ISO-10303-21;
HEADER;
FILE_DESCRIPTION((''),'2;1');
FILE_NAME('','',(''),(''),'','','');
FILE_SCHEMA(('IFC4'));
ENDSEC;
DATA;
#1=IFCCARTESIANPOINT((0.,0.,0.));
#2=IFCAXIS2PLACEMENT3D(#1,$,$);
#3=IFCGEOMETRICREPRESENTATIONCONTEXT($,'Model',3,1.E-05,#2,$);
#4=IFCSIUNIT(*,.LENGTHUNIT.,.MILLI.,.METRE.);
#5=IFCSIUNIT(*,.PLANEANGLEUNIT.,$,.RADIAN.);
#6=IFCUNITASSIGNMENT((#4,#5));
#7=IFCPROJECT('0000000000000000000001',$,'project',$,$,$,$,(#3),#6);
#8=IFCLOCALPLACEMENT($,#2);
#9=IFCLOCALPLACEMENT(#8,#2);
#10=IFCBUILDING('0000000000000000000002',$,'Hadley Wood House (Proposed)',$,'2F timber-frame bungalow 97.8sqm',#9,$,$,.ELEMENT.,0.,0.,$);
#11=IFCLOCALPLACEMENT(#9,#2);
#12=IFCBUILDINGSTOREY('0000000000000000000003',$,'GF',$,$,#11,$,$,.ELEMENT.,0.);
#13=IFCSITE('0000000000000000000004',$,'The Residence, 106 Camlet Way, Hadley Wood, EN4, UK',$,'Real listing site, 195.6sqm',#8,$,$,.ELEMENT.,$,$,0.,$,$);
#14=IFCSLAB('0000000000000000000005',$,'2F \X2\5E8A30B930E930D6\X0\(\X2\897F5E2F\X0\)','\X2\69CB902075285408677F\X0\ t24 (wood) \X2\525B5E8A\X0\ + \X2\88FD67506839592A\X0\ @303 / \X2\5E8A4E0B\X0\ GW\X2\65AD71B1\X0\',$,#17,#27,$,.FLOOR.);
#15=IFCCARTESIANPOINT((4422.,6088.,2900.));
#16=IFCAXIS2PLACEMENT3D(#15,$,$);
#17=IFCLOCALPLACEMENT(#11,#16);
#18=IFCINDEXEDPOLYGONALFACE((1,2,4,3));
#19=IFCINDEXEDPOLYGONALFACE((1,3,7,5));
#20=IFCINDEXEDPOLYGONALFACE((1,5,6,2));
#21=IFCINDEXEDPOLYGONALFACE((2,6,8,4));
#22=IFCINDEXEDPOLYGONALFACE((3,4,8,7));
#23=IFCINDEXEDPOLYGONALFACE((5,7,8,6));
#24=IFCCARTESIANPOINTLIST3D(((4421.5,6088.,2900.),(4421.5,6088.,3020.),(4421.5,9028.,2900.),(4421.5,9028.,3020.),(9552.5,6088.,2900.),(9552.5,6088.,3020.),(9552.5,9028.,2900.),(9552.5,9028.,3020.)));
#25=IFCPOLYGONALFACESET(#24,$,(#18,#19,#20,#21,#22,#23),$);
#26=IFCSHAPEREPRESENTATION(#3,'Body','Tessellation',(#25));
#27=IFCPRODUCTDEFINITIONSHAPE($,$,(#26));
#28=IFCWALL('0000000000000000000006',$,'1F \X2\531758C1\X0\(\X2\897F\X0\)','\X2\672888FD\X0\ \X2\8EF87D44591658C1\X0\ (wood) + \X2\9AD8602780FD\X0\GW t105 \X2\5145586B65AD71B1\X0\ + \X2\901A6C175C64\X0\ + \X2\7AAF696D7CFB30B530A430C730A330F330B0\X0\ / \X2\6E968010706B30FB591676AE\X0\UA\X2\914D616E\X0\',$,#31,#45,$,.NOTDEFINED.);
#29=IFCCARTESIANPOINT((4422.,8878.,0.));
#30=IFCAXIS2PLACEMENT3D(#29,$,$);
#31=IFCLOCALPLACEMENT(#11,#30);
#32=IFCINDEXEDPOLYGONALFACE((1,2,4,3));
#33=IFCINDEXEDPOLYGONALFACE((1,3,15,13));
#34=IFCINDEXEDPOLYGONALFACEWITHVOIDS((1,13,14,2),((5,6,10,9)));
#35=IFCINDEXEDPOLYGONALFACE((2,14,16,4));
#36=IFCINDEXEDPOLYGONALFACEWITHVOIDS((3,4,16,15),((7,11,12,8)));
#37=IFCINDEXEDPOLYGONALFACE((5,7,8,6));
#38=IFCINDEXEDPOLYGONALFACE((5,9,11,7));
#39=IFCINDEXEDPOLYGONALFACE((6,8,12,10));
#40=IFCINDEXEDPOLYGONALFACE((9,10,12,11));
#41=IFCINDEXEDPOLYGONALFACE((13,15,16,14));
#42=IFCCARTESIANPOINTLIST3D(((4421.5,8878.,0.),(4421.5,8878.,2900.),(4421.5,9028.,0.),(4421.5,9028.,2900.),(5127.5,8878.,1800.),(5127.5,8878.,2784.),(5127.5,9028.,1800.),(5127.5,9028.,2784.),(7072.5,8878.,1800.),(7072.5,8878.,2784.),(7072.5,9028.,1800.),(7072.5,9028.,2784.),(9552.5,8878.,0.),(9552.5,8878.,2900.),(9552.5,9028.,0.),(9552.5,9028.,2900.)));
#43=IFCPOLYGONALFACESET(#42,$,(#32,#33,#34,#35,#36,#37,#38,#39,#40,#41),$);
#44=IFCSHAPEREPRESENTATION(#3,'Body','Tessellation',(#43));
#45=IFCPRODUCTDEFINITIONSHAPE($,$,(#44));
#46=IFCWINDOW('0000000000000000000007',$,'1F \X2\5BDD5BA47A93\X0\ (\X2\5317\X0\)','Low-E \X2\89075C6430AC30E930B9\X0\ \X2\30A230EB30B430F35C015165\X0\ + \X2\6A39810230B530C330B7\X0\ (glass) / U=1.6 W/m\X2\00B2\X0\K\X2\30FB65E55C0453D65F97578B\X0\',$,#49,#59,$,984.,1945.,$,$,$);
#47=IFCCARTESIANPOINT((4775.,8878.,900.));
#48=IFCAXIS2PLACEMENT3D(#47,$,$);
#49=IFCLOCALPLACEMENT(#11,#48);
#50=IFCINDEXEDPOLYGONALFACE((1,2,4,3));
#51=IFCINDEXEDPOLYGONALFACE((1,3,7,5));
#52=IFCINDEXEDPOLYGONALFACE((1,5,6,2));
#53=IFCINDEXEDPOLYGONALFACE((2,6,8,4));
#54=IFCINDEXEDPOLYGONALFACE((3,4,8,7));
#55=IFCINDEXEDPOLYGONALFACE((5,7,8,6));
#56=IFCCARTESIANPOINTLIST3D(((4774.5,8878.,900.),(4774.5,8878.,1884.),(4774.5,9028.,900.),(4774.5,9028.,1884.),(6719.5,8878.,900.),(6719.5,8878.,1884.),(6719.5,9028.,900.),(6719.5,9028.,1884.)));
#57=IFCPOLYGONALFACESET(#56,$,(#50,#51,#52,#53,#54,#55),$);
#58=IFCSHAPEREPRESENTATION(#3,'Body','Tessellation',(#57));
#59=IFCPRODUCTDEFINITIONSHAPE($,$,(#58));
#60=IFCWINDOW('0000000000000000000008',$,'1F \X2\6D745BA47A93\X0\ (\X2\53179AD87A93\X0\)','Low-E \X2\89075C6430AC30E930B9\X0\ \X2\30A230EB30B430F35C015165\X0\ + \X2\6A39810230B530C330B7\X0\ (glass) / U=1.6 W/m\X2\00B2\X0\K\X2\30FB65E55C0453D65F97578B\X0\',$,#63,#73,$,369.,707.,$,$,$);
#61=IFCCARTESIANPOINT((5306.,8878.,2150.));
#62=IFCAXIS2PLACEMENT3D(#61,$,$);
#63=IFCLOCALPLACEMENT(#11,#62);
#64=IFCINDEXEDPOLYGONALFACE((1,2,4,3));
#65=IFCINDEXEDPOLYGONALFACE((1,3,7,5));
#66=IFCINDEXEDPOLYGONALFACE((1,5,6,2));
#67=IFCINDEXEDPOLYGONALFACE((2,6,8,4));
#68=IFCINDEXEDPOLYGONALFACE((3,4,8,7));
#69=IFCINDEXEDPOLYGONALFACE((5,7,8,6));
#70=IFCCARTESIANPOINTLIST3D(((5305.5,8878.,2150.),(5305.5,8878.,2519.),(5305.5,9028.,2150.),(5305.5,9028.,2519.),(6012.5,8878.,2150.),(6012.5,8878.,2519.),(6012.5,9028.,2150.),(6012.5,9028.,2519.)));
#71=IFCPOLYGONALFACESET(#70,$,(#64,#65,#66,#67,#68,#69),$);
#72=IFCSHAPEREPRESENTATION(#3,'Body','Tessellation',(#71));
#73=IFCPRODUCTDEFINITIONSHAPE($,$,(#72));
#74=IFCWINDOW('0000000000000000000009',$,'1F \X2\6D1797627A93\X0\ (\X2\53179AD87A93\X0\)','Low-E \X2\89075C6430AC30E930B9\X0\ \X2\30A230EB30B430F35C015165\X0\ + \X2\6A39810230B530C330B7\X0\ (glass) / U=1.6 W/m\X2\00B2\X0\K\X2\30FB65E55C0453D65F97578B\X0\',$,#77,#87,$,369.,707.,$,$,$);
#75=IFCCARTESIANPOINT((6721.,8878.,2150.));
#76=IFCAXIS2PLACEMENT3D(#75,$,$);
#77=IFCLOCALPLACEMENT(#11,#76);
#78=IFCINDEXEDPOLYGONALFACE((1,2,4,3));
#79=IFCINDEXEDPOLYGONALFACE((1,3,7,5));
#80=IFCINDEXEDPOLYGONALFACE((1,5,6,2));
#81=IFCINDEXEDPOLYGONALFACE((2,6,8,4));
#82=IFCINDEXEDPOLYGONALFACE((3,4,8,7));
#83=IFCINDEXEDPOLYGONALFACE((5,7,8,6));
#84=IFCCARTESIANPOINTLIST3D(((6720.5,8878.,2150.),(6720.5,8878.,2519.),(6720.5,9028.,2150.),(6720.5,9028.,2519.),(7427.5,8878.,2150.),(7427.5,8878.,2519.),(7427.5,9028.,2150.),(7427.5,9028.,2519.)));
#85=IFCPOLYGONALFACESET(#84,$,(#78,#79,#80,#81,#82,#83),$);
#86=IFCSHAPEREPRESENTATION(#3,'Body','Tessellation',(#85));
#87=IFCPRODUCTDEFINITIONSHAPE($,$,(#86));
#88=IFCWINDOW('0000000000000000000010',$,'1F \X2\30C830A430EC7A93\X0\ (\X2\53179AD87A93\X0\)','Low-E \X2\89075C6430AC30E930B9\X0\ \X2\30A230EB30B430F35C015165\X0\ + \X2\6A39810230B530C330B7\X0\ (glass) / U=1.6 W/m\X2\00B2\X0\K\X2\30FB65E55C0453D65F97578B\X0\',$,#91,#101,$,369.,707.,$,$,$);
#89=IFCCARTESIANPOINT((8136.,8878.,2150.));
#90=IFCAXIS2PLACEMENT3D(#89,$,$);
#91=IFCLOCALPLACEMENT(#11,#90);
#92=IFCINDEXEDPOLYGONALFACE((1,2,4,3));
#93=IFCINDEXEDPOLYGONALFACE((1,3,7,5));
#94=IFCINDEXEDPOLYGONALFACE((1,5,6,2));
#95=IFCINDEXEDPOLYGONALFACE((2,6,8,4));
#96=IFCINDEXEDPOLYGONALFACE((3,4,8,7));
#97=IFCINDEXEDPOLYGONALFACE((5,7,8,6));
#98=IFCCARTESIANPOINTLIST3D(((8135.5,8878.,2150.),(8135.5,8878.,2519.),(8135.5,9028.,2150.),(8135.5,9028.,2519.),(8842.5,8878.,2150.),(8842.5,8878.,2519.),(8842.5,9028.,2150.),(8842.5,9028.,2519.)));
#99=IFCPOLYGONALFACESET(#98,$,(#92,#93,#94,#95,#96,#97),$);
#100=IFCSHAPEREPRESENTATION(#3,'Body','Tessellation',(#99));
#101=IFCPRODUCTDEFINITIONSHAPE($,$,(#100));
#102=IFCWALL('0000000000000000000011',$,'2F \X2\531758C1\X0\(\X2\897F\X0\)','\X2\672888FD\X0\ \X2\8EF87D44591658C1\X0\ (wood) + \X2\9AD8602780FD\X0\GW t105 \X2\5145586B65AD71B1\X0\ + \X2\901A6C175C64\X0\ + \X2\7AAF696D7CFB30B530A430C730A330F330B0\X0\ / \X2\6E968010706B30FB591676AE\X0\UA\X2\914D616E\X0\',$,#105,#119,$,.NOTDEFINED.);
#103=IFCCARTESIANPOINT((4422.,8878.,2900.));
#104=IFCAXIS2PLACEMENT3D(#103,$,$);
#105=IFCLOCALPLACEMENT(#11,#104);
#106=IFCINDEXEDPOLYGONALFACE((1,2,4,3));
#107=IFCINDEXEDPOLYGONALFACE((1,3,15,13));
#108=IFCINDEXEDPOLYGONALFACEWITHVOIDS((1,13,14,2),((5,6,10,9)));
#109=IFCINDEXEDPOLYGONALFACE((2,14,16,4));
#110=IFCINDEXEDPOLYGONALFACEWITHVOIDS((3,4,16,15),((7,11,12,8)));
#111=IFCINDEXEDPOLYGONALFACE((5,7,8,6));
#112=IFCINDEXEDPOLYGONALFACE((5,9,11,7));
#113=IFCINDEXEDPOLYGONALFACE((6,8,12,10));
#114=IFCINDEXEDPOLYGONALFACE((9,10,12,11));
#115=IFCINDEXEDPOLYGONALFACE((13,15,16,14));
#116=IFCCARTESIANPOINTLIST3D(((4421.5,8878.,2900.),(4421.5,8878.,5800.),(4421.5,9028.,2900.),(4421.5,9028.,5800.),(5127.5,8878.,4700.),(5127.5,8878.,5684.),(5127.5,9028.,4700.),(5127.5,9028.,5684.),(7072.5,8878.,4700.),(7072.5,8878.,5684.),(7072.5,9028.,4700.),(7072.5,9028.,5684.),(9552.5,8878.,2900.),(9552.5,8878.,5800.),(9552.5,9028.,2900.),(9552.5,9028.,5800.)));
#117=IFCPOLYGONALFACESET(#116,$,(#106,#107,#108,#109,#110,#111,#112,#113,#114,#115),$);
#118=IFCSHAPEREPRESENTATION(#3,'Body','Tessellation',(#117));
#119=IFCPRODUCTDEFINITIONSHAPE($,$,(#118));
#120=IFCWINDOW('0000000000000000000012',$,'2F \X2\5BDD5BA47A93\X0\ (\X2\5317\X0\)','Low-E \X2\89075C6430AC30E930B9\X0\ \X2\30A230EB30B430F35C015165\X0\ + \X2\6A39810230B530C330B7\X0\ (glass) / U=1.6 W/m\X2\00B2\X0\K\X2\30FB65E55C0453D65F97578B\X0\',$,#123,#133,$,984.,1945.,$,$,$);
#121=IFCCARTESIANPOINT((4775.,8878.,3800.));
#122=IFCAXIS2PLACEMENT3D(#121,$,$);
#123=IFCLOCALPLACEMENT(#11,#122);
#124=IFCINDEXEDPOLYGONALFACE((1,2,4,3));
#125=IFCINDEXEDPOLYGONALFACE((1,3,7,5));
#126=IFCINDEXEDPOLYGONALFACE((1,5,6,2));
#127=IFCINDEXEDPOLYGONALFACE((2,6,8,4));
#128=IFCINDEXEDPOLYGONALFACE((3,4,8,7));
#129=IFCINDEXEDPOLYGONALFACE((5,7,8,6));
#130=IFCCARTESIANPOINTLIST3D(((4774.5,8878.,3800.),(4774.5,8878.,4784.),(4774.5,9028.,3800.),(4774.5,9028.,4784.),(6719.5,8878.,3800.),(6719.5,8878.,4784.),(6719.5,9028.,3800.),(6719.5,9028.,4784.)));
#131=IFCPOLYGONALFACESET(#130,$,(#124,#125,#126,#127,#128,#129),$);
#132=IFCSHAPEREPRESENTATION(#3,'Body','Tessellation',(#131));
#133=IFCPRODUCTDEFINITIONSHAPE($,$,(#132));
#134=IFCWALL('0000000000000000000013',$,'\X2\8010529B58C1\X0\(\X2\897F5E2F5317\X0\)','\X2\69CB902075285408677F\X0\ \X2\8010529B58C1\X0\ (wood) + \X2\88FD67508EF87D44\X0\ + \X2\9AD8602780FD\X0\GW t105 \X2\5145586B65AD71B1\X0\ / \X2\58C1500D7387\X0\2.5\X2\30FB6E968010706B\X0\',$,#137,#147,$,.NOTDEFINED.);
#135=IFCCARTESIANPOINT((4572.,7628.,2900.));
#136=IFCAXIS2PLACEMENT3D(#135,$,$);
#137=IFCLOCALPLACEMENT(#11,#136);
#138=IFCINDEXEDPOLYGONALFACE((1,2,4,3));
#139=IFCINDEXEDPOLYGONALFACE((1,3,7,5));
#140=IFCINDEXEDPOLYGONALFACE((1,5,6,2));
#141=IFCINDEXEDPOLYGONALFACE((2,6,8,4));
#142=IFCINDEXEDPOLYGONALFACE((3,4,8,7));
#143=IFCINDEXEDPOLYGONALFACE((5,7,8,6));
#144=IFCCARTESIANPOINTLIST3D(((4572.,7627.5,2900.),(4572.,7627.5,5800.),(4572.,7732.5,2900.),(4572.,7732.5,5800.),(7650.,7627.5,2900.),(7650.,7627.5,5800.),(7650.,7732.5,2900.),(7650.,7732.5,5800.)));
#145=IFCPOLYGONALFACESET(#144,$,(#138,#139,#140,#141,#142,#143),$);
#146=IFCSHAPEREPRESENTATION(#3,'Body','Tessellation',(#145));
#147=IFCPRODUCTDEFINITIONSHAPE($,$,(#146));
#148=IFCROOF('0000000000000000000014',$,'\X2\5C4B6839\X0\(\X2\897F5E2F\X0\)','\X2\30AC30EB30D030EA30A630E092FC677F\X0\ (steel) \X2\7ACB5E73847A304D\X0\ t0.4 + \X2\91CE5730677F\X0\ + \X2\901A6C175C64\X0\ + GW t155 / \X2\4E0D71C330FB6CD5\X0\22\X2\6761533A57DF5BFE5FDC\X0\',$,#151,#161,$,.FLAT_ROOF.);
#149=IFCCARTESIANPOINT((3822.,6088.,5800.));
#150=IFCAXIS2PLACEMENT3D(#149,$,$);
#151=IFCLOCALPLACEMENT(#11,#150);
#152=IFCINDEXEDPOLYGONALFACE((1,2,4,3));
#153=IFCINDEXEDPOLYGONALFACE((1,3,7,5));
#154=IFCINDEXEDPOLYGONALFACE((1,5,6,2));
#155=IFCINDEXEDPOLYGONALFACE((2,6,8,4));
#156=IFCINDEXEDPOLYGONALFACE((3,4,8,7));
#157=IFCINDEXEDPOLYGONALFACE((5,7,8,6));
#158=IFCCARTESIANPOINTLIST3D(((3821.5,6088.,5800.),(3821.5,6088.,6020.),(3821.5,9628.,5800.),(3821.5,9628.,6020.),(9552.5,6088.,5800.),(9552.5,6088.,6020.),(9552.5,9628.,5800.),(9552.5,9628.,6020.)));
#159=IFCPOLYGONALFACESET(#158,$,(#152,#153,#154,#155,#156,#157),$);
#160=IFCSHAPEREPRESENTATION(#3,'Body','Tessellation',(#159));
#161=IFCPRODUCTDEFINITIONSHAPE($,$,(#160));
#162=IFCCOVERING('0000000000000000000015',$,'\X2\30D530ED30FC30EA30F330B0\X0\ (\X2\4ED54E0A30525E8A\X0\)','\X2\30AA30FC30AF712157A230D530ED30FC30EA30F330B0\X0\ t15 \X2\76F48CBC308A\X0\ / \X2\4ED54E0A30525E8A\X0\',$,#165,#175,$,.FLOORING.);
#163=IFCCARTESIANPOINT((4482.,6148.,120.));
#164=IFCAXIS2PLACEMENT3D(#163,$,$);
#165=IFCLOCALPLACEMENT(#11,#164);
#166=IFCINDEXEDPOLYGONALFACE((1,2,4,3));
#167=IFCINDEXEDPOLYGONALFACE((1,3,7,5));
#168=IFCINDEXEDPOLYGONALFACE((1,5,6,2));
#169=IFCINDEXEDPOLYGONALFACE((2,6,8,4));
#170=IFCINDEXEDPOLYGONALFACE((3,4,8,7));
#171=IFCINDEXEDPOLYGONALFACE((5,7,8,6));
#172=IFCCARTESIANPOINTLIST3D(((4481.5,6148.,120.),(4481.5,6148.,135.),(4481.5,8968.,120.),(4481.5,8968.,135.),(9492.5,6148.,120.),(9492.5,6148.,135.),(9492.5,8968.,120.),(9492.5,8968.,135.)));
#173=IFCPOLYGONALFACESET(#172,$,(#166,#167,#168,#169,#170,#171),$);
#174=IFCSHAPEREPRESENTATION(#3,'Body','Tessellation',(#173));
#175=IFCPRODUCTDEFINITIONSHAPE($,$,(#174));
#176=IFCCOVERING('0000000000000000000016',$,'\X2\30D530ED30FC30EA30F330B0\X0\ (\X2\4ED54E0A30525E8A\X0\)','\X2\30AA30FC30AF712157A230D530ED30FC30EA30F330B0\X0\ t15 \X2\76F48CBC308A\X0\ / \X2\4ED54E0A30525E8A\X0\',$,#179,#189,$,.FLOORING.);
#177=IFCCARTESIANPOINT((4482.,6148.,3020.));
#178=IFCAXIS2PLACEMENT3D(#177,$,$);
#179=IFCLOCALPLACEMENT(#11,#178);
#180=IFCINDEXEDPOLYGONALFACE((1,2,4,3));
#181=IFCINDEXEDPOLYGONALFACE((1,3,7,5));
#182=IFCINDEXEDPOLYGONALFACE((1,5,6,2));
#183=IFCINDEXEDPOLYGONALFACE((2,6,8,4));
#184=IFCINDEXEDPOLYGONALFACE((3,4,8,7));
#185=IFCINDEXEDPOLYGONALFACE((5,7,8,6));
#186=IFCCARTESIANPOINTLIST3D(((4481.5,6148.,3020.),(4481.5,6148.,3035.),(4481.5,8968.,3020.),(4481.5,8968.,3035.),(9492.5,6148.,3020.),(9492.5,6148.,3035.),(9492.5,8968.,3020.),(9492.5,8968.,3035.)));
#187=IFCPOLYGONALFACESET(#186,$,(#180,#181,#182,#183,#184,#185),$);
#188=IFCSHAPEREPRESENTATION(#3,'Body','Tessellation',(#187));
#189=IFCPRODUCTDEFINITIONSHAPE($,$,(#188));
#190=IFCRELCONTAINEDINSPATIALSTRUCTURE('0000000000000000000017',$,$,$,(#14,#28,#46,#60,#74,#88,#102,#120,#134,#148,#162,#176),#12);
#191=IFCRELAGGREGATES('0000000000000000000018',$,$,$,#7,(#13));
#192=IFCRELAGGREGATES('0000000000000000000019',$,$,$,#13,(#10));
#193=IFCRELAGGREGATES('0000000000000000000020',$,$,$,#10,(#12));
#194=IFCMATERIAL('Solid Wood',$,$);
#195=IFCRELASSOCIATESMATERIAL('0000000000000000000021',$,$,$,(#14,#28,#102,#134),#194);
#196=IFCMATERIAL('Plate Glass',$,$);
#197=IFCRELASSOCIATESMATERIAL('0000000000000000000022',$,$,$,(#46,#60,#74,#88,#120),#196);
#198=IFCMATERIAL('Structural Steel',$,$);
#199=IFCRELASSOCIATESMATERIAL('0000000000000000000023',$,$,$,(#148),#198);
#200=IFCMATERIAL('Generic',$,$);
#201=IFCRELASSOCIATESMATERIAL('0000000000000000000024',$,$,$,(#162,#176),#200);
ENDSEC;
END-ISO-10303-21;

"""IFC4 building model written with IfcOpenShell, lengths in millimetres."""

from ifc_helpers import new_model, si_unit, frame, frame_2d, origin, place, context, project, spatial, rectangle, extrude, material, element, fill, save


model = new_model("IFC4")

# Units and contexts
model_context = context("Model", 3, precision=1e-05, world=origin())
ifc_project = project(units=[si_unit("LENGTHUNIT", "METRE", prefix="MILLI"), si_unit("PLANEANGLEUNIT", "RADIAN")], contexts=[model_context])

# Site, building, storey
site_placement = place(None, origin())
site = spatial("IfcSite", under=ifc_project, at=site_placement, Name="The Residence, 106 Camlet Way, Hadley Wood, EN4, UK", ObjectType="Real listing site, 195.6sqm", CompositionType="ELEMENT", RefElevation=0.0)
building_placement = place(site_placement, origin())
building = spatial("IfcBuilding", under=site, at=building_placement, Name="Hadley Wood House (Proposed)", ObjectType="2F timber-frame bungalow 97.8sqm", CompositionType="ELEMENT", ElevationOfRefHeight=0.0, ElevationOfTerrain=0.0)
storey_placement = place(building_placement, origin())
storey = spatial("IfcBuildingStorey", under=building, at=storey_placement, Name="GF", CompositionType="ELEMENT", Elevation=0.0)

# Slab
ifc_material_1 = material(Name="Solid Wood")
slab_1_placement = place(storey_placement, frame((4422.0, 6088.0, 2900.0)))
element("IfcSlab", 1, at=slab_1_placement, inside=storey, material=ifc_material_1, Name="2F 床スラブ(西帯)", Description="構造用合板 t24 (wood) 剛床 + 製材根太 @303 / 床下 GW断熱", PredefinedType="FLOOR", context=model_context, shape_type="SweptSolid", body=[
    extrude(rectangle(XDim=5131.0, YDim=2940.0, at=frame_2d((2565.0, 1470.0))), frame((4422.0, 6088.0, 2900.0)), (0.0, 0.0, 1.0), 120.0),
])

# Wall, openings, windows
wall_1_placement = place(storey_placement, frame((4422.0, 8878.0, 0.0)))
wall_1 = element("IfcWall", 2, at=wall_1_placement, inside=storey, material=ifc_material_1, Name="1F 北壁(西)", Description="木製 軸組外壁 (wood) + 高性能GW t105 充填断熱 + 通気層 + 窯業系サイディング / 準耐火・外皮UA配慮", PredefinedType="NOTDEFINED", context=model_context, shape_type="SweptSolid", body=[
    extrude(rectangle(XDim=5131.0, YDim=150.0, at=frame_2d((2565.0, 75.0))), frame((4422.0, 8878.0, 0.0)), (0.0, 0.0, 1.0), 2900.0),
])
opening_1_placement = place(storey_placement, frame((4775.0, 8878.0, 900.0)))
opening_1 = element("IfcOpeningElement", 3, at=opening_1_placement, cuts=wall_1, PredefinedType="NOTDEFINED", context=model_context, shape_type="SweptSolid", body=[
    extrude(rectangle(XDim=1945.0, YDim=150.0, at=frame_2d((972.0, 75.0))), frame((4775.0, 8878.0, 900.0)), (0.0, 0.0, 1.0), 984.0),
])
opening_2_placement = place(storey_placement, frame((5306.0, 8878.0, 2150.0)))
opening_2 = element("IfcOpeningElement", 4, at=opening_2_placement, cuts=wall_1, PredefinedType="NOTDEFINED", context=model_context, shape_type="SweptSolid", body=[
    extrude(rectangle(XDim=707.0, YDim=150.0, at=frame_2d((353.0, 75.0))), frame((5306.0, 8878.0, 2150.0)), (0.0, 0.0, 1.0), 369.0),
])
opening_3_placement = place(storey_placement, frame((6721.0, 8878.0, 2150.0)))
opening_3 = element("IfcOpeningElement", 5, at=opening_3_placement, cuts=wall_1, PredefinedType="NOTDEFINED", context=model_context, shape_type="SweptSolid", body=[
    extrude(rectangle(XDim=707.0, YDim=150.0, at=frame_2d((353.0, 75.0))), frame((6721.0, 8878.0, 2150.0)), (0.0, 0.0, 1.0), 369.0),
])
opening_4_placement = place(storey_placement, frame((8136.0, 8878.0, 2150.0)))
opening_4 = element("IfcOpeningElement", 6, at=opening_4_placement, cuts=wall_1, PredefinedType="NOTDEFINED", context=model_context, shape_type="SweptSolid", body=[
    extrude(rectangle(XDim=707.0, YDim=150.0, at=frame_2d((353.0, 75.0))), frame((8136.0, 8878.0, 2150.0)), (0.0, 0.0, 1.0), 369.0),
])
ifc_material_2 = material(Name="Plate Glass")
window_1_placement = place(storey_placement, frame((4775.0, 8878.0, 900.0)))
window_1 = element("IfcWindow", 7, at=window_1_placement, inside=storey, material=ifc_material_2, Name="1F 寝室窓 (北)", Description="Low-E 複層ガラス アルゴン封入 + 樹脂サッシ (glass) / U=1.6 W/m²K・日射取得型", OverallHeight=984.0, OverallWidth=1945.0, context=model_context, shape_type="SweptSolid", body=[
    extrude(rectangle(XDim=1945.0, YDim=150.0, at=frame_2d((972.0, 75.0))), frame((4775.0, 8878.0, 900.0)), (0.0, 0.0, 1.0), 984.0),
])
fill(opening_1, window_1)
window_2_placement = place(storey_placement, frame((5306.0, 8878.0, 2150.0)))
window_2 = element("IfcWindow", 8, at=window_2_placement, inside=storey, material=ifc_material_2, Name="1F 浴室窓 (北高窓)", Description="Low-E 複層ガラス アルゴン封入 + 樹脂サッシ (glass) / U=1.6 W/m²K・日射取得型", OverallHeight=369.0, OverallWidth=707.0, context=model_context, shape_type="SweptSolid", body=[
    extrude(rectangle(XDim=707.0, YDim=150.0, at=frame_2d((353.0, 75.0))), frame((5306.0, 8878.0, 2150.0)), (0.0, 0.0, 1.0), 369.0),
])
fill(opening_2, window_2)
window_3_placement = place(storey_placement, frame((6721.0, 8878.0, 2150.0)))
window_3 = element("IfcWindow", 9, at=window_3_placement, inside=storey, material=ifc_material_2, Name="1F 洗面窓 (北高窓)", Description="Low-E 複層ガラス アルゴン封入 + 樹脂サッシ (glass) / U=1.6 W/m²K・日射取得型", OverallHeight=369.0, OverallWidth=707.0, context=model_context, shape_type="SweptSolid", body=[
    extrude(rectangle(XDim=707.0, YDim=150.0, at=frame_2d((353.0, 75.0))), frame((6721.0, 8878.0, 2150.0)), (0.0, 0.0, 1.0), 369.0),
])
fill(opening_3, window_3)
window_4_placement = place(storey_placement, frame((8136.0, 8878.0, 2150.0)))
window_4 = element("IfcWindow", 10, at=window_4_placement, inside=storey, material=ifc_material_2, Name="1F トイレ窓 (北高窓)", Description="Low-E 複層ガラス アルゴン封入 + 樹脂サッシ (glass) / U=1.6 W/m²K・日射取得型", OverallHeight=369.0, OverallWidth=707.0, context=model_context, shape_type="SweptSolid", body=[
    extrude(rectangle(XDim=707.0, YDim=150.0, at=frame_2d((353.0, 75.0))), frame((8136.0, 8878.0, 2150.0)), (0.0, 0.0, 1.0), 369.0),
])
fill(opening_4, window_4)

# Wall, opening, window
wall_2_placement = place(storey_placement, frame((4422.0, 8878.0, 2900.0)))
wall_2 = element("IfcWall", 11, at=wall_2_placement, inside=storey, material=ifc_material_1, Name="2F 北壁(西)", Description="木製 軸組外壁 (wood) + 高性能GW t105 充填断熱 + 通気層 + 窯業系サイディング / 準耐火・外皮UA配慮", PredefinedType="NOTDEFINED", context=model_context, shape_type="SweptSolid", body=[
    extrude(rectangle(XDim=5131.0, YDim=150.0, at=frame_2d((2565.0, 75.0))), frame((4422.0, 8878.0, 2900.0)), (0.0, 0.0, 1.0), 2900.0),
])
opening_5_placement = place(storey_placement, frame((4775.0, 8878.0, 3800.0)))
opening_5 = element("IfcOpeningElement", 12, at=opening_5_placement, cuts=wall_2, PredefinedType="NOTDEFINED", context=model_context, shape_type="SweptSolid", body=[
    extrude(rectangle(XDim=1945.0, YDim=150.0, at=frame_2d((972.0, 75.0))), frame((4775.0, 8878.0, 3800.0)), (0.0, 0.0, 1.0), 984.0),
])
window_5_placement = place(storey_placement, frame((4775.0, 8878.0, 3800.0)))
window_5 = element("IfcWindow", 13, at=window_5_placement, inside=storey, material=ifc_material_2, Name="2F 寝室窓 (北)", Description="Low-E 複層ガラス アルゴン封入 + 樹脂サッシ (glass) / U=1.6 W/m²K・日射取得型", OverallHeight=984.0, OverallWidth=1945.0, context=model_context, shape_type="SweptSolid", body=[
    extrude(rectangle(XDim=1945.0, YDim=150.0, at=frame_2d((972.0, 75.0))), frame((4775.0, 8878.0, 3800.0)), (0.0, 0.0, 1.0), 984.0),
])
fill(opening_5, window_5)

# Wall
wall_3_placement = place(storey_placement, frame((4572.0, 7628.0, 2900.0)))
element("IfcWall", 14, at=wall_3_placement, inside=storey, material=ifc_material_1, Name="耐力壁(西帯北)", Description="構造用合板 耐力壁 (wood) + 製材軸組 + 高性能GW t105 充填断熱 / 壁倍率2.5・準耐火", PredefinedType="NOTDEFINED", context=model_context, shape_type="SweptSolid", body=[
    extrude(rectangle(XDim=3078.0, YDim=105.0, at=frame_2d((1539.0, 52.0))), frame((4572.0, 7628.0, 2900.0)), (0.0, 0.0, 1.0), 2900.0),
])

# Roof
ifc_material_3 = material(Name="Structural Steel")
for number, where, name in (
    (15, (3822.0, 6088.0, 5800.0), "屋根(西帯)"),
):
    element("IfcRoof", number, at=place(storey_placement, frame(where)), inside=storey, material=ifc_material_3, Name=name, Description="ガルバリウム鋼板 (steel) 立平葺き t0.4 + 野地板 + 通気層 + GW t155 / 不燃・法22条区域対応", PredefinedType="FLAT_ROOF", context=model_context, shape_type="SweptSolid", body=[
        extrude(rectangle(XDim=5731.0, YDim=3540.0, at=frame_2d((2865.0, 1770.0))), frame((3822.0, 6088.0, 5800.0)), (0.0, 0.0, 1.0), 220.0),
    ])

# Coverings
ifc_material_4 = material(Name="Generic")
covering_1_placement = place(storey_placement, frame((4482.0, 6148.0, 120.0)))
element("IfcCovering", 16, at=covering_1_placement, inside=storey, material=ifc_material_4, Name="フローリング (仕上げ床)", Description="オーク無垢フローリング t15 直貼り / 仕上げ床", PredefinedType="FLOORING", context=model_context, shape_type="SweptSolid", body=[
    extrude(rectangle(XDim=5011.0, YDim=2820.0, at=frame_2d((2505.0, 1410.0))), frame((4482.0, 6148.0, 120.0)), (0.0, 0.0, 1.0), 15.0),
])
covering_2_placement = place(storey_placement, frame((4482.0, 6148.0, 3020.0)))
element("IfcCovering", 17, at=covering_2_placement, inside=storey, material=ifc_material_4, Name="フローリング (仕上げ床)", Description="オーク無垢フローリング t15 直貼り / 仕上げ床", PredefinedType="FLOORING", context=model_context, shape_type="SweptSolid", body=[
    extrude(rectangle(XDim=5011.0, YDim=2820.0, at=frame_2d((2505.0, 1410.0))), frame((4482.0, 6148.0, 3020.0)), (0.0, 0.0, 1.0), 15.0),
])

save(model, "model.ifc")
